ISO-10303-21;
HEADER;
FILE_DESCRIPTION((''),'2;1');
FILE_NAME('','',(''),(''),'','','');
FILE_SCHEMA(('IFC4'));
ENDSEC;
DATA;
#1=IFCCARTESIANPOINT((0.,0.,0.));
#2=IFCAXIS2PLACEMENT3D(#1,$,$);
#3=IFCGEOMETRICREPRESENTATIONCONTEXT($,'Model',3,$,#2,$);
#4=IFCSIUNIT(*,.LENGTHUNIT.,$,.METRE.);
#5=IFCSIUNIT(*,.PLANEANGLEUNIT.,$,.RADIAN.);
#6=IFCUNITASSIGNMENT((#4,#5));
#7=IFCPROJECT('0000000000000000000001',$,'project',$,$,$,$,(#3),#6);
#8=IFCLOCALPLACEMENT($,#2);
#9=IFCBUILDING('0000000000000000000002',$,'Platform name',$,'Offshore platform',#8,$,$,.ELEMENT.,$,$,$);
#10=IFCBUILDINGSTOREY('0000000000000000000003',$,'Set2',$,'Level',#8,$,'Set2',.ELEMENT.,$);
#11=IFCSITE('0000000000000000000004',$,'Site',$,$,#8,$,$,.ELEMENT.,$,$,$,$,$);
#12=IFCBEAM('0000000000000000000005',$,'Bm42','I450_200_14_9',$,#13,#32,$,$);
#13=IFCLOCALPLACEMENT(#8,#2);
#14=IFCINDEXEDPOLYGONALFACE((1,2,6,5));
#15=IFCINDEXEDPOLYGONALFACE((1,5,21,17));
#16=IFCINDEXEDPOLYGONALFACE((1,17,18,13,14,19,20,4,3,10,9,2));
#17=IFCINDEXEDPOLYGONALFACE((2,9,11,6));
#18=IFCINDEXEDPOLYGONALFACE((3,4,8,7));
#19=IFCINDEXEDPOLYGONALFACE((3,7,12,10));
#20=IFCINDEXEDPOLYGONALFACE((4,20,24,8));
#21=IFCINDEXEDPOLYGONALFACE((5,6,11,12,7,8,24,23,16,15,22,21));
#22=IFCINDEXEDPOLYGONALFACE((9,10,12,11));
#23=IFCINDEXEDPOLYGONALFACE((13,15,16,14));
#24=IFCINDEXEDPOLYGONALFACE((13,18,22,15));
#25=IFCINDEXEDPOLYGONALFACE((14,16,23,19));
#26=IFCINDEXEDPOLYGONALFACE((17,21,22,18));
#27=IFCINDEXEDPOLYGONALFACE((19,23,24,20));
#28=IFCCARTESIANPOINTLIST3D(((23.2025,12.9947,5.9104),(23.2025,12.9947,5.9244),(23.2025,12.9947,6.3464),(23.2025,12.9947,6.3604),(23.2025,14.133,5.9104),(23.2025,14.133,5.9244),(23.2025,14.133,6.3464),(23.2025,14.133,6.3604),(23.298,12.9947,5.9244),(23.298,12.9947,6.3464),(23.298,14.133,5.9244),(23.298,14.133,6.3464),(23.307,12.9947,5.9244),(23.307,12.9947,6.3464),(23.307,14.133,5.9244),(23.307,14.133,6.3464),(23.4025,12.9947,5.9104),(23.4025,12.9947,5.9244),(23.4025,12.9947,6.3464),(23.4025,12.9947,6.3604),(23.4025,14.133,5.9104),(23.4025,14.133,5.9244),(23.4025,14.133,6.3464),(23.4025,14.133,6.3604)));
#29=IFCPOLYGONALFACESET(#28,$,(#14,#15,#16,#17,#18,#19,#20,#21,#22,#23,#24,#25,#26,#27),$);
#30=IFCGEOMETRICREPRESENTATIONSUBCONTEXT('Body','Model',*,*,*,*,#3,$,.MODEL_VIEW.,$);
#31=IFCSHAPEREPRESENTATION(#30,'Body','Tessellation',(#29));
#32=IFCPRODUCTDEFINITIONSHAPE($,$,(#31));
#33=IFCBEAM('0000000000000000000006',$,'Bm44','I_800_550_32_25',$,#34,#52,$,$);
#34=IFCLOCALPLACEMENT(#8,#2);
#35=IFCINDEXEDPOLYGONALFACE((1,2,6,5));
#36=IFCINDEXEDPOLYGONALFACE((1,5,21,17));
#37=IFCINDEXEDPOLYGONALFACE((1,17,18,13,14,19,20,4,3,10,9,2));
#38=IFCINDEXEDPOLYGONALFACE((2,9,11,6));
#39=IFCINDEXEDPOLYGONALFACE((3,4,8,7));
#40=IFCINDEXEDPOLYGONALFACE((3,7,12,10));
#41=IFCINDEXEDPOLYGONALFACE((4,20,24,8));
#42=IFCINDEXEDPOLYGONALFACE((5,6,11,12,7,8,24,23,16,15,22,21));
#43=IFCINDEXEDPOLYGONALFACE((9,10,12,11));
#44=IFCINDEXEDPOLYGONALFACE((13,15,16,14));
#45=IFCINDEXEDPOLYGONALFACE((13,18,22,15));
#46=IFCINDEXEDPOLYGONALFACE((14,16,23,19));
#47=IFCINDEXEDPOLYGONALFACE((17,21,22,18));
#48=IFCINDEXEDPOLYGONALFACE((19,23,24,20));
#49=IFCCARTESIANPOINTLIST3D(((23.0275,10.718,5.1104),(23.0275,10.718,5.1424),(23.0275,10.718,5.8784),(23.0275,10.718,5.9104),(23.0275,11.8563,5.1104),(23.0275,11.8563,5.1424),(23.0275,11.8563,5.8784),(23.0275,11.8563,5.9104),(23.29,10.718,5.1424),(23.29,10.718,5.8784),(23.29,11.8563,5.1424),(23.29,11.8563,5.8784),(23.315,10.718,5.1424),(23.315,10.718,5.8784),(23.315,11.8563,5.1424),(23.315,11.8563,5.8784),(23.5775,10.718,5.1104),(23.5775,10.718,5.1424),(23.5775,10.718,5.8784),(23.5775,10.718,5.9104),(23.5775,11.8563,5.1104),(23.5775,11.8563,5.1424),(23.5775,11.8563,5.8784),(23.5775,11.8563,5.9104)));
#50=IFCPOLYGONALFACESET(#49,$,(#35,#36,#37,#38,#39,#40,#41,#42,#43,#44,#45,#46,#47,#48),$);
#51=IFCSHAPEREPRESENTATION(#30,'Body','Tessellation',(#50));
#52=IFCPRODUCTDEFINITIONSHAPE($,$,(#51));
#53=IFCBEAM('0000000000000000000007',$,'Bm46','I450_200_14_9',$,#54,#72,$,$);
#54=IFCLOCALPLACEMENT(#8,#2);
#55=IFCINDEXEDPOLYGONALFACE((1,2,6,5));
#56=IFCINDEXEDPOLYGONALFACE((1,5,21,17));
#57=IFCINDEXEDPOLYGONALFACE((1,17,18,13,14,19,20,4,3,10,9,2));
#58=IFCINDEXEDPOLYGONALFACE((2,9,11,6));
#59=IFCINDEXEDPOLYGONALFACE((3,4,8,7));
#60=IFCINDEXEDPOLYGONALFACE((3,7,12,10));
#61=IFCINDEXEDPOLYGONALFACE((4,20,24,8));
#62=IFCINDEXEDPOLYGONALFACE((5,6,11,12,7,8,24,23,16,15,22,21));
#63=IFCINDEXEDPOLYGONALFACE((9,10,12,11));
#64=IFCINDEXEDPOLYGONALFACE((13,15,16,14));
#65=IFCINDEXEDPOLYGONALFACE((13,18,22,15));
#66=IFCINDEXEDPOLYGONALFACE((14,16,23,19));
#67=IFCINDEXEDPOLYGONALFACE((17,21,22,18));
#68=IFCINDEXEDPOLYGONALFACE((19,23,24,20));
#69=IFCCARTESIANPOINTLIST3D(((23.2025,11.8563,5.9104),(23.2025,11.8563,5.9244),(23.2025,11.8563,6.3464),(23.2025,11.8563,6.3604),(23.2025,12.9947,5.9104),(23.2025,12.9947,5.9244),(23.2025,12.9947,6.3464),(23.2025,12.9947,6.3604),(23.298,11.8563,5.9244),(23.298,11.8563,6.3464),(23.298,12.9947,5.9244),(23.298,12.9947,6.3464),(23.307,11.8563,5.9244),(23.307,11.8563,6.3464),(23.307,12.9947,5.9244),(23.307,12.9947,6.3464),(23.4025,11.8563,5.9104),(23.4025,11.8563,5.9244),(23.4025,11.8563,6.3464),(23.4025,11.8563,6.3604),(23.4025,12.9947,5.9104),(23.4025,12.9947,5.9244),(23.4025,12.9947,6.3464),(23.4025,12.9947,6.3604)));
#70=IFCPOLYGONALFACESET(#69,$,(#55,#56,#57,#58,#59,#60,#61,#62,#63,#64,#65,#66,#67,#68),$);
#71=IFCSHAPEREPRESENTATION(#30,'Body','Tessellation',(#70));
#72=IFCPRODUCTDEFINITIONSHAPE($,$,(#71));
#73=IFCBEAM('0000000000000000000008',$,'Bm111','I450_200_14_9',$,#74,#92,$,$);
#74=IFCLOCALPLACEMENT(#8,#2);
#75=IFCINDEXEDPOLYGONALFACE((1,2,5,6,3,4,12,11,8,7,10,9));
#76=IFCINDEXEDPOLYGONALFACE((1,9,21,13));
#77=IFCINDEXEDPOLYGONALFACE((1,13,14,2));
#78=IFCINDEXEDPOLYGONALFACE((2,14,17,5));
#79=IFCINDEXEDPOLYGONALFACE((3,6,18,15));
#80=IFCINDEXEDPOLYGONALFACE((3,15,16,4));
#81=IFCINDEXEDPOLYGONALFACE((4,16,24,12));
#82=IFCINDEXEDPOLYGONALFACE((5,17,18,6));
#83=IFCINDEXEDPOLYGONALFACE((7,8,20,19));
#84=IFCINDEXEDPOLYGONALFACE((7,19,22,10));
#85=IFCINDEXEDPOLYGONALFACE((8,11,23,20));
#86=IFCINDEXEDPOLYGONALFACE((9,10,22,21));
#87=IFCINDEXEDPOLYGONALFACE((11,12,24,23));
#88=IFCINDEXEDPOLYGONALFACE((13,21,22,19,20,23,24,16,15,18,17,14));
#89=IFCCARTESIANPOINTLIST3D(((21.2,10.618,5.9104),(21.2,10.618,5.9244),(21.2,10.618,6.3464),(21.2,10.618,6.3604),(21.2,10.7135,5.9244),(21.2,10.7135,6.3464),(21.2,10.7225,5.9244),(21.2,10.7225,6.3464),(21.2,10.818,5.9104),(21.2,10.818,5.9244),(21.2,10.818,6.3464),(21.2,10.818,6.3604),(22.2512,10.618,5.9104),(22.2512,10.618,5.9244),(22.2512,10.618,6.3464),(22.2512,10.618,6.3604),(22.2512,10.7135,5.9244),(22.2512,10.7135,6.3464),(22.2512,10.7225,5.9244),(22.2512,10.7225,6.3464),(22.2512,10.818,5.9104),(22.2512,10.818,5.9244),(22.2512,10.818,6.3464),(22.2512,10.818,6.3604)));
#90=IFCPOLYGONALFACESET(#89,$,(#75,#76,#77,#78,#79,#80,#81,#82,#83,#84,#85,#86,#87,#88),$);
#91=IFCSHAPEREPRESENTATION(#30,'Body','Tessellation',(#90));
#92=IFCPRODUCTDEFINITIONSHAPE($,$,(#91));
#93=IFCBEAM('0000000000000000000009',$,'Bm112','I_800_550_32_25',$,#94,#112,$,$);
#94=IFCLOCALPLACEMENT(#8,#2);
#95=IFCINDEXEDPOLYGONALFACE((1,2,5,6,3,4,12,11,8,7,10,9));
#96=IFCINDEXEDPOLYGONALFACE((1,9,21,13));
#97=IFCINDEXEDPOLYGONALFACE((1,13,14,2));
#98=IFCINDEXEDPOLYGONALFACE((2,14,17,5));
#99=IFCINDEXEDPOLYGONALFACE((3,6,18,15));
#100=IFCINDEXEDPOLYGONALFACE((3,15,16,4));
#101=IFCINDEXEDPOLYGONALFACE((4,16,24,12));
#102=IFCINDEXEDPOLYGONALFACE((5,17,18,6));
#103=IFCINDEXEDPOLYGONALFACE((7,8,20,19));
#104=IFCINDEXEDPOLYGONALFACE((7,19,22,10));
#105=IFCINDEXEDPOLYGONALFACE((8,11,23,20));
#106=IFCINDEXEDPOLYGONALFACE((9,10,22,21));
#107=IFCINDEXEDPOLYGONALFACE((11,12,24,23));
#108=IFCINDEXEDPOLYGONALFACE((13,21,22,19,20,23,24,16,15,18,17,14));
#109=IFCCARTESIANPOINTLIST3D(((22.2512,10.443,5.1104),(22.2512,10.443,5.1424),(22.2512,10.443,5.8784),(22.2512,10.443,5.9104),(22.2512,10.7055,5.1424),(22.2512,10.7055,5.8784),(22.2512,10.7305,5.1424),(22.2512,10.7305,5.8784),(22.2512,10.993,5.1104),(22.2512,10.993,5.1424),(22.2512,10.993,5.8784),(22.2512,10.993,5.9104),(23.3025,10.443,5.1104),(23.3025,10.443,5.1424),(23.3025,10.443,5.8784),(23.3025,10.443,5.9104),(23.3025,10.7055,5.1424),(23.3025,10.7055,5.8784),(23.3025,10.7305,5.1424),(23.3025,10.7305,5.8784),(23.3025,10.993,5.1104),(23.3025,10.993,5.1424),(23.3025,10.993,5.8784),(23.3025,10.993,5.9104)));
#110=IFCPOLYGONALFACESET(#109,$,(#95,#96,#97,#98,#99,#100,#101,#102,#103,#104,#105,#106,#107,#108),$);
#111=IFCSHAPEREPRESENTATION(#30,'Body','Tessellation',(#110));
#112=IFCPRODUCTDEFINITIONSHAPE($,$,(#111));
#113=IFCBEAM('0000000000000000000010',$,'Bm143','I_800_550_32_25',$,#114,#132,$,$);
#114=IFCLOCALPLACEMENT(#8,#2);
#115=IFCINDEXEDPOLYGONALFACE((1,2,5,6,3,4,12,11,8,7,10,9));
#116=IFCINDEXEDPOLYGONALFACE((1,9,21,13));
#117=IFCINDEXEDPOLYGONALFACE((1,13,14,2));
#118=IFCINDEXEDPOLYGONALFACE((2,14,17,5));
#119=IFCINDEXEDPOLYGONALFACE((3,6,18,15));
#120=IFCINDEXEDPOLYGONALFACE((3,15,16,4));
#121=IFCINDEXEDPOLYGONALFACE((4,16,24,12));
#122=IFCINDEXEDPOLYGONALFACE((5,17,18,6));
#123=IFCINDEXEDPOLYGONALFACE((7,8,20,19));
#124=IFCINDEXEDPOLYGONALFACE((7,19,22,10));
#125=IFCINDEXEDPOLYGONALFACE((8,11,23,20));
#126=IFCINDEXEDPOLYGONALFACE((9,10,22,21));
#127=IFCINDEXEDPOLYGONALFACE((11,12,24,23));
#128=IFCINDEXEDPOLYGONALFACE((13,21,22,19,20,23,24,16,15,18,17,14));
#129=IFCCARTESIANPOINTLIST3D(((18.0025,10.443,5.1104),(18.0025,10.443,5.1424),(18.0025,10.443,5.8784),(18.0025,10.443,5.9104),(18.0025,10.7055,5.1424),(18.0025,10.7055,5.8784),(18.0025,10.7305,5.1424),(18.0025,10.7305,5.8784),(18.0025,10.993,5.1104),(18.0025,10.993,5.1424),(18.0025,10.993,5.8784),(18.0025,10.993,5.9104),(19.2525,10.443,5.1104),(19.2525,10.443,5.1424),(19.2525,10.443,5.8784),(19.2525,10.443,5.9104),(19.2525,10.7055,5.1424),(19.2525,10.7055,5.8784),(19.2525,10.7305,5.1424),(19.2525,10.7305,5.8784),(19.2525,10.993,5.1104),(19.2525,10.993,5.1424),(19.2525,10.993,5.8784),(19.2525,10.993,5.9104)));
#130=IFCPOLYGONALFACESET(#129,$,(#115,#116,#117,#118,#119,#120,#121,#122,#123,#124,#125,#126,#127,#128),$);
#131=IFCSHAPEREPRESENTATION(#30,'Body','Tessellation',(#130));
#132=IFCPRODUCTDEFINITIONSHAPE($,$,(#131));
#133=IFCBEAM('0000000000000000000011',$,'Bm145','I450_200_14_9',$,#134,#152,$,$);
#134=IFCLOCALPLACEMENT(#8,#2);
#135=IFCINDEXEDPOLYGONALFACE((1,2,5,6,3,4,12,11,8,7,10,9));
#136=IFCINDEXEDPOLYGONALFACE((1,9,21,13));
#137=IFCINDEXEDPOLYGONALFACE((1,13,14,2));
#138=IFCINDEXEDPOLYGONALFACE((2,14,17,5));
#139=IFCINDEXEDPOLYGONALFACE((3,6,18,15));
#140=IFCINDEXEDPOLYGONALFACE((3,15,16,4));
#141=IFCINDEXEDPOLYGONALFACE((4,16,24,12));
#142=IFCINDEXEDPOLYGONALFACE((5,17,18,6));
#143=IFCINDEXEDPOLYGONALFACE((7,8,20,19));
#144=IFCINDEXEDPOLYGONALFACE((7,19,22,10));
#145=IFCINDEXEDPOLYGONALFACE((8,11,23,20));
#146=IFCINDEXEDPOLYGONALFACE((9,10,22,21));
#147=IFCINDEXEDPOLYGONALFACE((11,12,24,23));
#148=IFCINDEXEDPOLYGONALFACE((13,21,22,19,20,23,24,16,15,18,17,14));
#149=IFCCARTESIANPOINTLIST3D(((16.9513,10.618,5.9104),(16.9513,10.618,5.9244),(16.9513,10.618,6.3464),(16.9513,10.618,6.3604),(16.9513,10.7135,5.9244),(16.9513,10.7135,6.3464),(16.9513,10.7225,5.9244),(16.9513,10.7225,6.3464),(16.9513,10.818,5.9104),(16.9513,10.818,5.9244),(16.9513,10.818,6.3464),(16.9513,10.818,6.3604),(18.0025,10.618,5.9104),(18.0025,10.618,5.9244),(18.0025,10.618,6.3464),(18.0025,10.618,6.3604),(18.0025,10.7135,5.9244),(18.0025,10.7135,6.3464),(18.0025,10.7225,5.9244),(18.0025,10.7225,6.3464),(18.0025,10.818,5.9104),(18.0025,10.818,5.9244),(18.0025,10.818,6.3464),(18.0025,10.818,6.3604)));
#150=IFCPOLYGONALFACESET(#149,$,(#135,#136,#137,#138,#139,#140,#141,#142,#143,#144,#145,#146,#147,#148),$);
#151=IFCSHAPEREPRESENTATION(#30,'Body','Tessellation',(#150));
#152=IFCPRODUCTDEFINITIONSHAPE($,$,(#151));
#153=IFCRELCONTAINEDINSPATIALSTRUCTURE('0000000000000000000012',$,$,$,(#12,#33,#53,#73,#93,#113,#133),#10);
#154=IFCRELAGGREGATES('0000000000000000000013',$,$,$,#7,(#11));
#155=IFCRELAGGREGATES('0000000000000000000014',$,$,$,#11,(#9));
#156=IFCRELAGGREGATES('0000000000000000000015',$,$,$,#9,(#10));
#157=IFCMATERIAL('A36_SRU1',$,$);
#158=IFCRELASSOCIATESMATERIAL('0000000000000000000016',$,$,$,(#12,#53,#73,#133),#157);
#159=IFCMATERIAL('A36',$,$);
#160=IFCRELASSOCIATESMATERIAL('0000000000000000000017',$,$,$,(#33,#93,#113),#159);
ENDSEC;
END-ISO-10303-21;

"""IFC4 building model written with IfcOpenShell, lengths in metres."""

from ifc_helpers import new_model, si_unit, frame, origin, origin_2d, place, context, subcontext, project, spatial, i_section, extrude, source, transform, mapped, material, element, save


model = new_model("IFC4")

# Units and contexts
model_context = context("Model", 3, world=origin())
body_context = subcontext(model_context, "Body", "Model", "MODEL_VIEW")
ifc_project = project(units=[si_unit("LENGTHUNIT", "METRE"), si_unit("PLANEANGLEUNIT", "RADIAN")], contexts=[model_context])

# Site, building, storey
placement_1 = place(None, origin())
site = spatial("IfcSite", under=ifc_project, at=placement_1, Name="Site", CompositionType="ELEMENT")
building = spatial("IfcBuilding", under=site, at=placement_1, Name="Platform name", ObjectType="Offshore platform", CompositionType="ELEMENT")
storey = spatial("IfcBuildingStorey", under=building, at=placement_1, Name="Set2", ObjectType="Level", LongName="Set2", CompositionType="ELEMENT")

# Beams
ifc_material_1 = material(Name="A36_SRU1")
ifc_material_2 = material(Name="A36")
shared_shape_1 = source(origin(), body_context, "Body", "SweptSolid", [
    extrude(i_section(OverallWidth=0.2, OverallDepth=0.45, WebThickness=0.009, FlangeThickness=0.014, FilletRadius=0.0, at=origin_2d()), frame((0.0, 0.0, 0.0), z_axis=(0.0, 1.0, 0.0), x_axis=(-1.0, 0.0, 0.0)), (0.0, 0.0, 1.0), 1.1383),
])
placement_2 = place(None, origin())
placement_3 = place(placement_2, origin())
placement_4 = place(placement_3, origin())
beam_1_placement = place(placement_4, frame((23.3025, 12.9947, 6.1354)))
element("IfcBeam", 1, at=beam_1_placement, inside=storey, material=ifc_material_1, Name="Bm42", Description="I450_200_14_9", context=body_context, shape_type="MappedRepresentation", body=[
    mapped(shared_shape_1, transform((0.0, 0.0, 0.0), scale=1.0)),
])
shared_shape_2 = source(origin(), body_context, "Body", "SweptSolid", [
    extrude(i_section(OverallWidth=0.55, OverallDepth=0.8, WebThickness=0.025, FlangeThickness=0.032, FilletRadius=0.0, at=origin_2d()), frame((0.0, 0.0, 0.0), z_axis=(0.0, -1.0, 0.0), x_axis=(1.0, 0.0, 0.0)), (0.0, 0.0, 1.0), 1.1383),
])
placement_5 = place(None, origin())
placement_6 = place(placement_5, origin())
placement_7 = place(placement_6, origin())
beam_2_placement = place(placement_7, frame((23.3025, 11.8563, 5.5104)))
element("IfcBeam", 2, at=beam_2_placement, inside=storey, material=ifc_material_2, Name="Bm44", Description="I_800_550_32_25", context=body_context, shape_type="MappedRepresentation", body=[
    mapped(shared_shape_2, transform((0.0, 0.0, 0.0), scale=1.0)),
])
shared_shape_3 = source(origin(), body_context, "Body", "SweptSolid", [
    extrude(i_section(OverallWidth=0.2, OverallDepth=0.45, WebThickness=0.009, FlangeThickness=0.014, FilletRadius=0.0, at=origin_2d()), frame((0.0, 0.0, 0.0), z_axis=(0.0, 1.0, 0.0), x_axis=(-1.0, 0.0, 0.0)), (0.0, 0.0, 1.0), 1.1383),
])
placement_8 = place(None, origin())
placement_9 = place(placement_8, origin())
placement_10 = place(placement_9, origin())
beam_3_placement = place(placement_10, frame((23.3025, 11.8563, 6.1354)))
element("IfcBeam", 3, at=beam_3_placement, inside=storey, material=ifc_material_1, Name="Bm46", Description="I450_200_14_9", context=body_context, shape_type="MappedRepresentation", body=[
    mapped(shared_shape_3, transform((0.0, 0.0, 0.0), scale=1.0)),
])
shared_shape_4 = source(origin(), body_context, "Body", "SweptSolid", [
    extrude(i_section(OverallWidth=0.2, OverallDepth=0.45, WebThickness=0.009, FlangeThickness=0.014, FilletRadius=0.0, at=origin_2d()), frame((0.0, 0.0, 0.0), z_axis=(-1.0, 0.0, 0.0), x_axis=(0.0, -1.0, 0.0)), (0.0, 0.0, 1.0), 1.0513),
])
placement_11 = place(None, origin())
placement_12 = place(placement_11, origin())
placement_13 = place(placement_12, origin())
beam_4_placement = place(placement_13, frame((22.2512, 10.718, 6.1354)))
element("IfcBeam", 4, at=beam_4_placement, inside=storey, material=ifc_material_1, Name="Bm111", Description="I450_200_14_9", context=body_context, shape_type="MappedRepresentation", body=[
    mapped(shared_shape_4, transform((0.0, 0.0, 0.0), scale=1.0)),
])
shared_shape_5 = source(origin(), body_context, "Body", "SweptSolid", [
    extrude(i_section(OverallWidth=0.55, OverallDepth=0.8, WebThickness=0.025, FlangeThickness=0.032, FilletRadius=0.0, at=origin_2d()), frame((0.0, 0.0, 0.0), z_axis=(1.0, 0.0, 0.0), x_axis=(0.0, 1.0, 0.0)), (0.0, 0.0, 1.0), 1.0513),
])
placement_14 = place(None, origin())
placement_15 = place(placement_14, origin())
placement_16 = place(placement_15, origin())
beam_5_placement = place(placement_16, frame((22.2512, 10.718, 5.5104)))
element("IfcBeam", 5, at=beam_5_placement, inside=storey, material=ifc_material_2, Name="Bm112", Description="I_800_550_32_25", context=body_context, shape_type="MappedRepresentation", body=[
    mapped(shared_shape_5, transform((0.0, 0.0, 0.0), scale=1.0)),
])
shared_shape_6 = source(origin(), body_context, "Body", "SweptSolid", [
    extrude(i_section(OverallWidth=0.55, OverallDepth=0.8, WebThickness=0.025, FlangeThickness=0.032, FilletRadius=0.0, at=origin_2d()), frame((0.0, 0.0, 0.0), z_axis=(1.0, 0.0, 0.0), x_axis=(0.0, 1.0, 0.0)), (0.0, 0.0, 1.0), 1.25),
])
placement_17 = place(None, origin())
placement_18 = place(placement_17, origin())
placement_19 = place(placement_18, origin())
beam_6_placement = place(placement_19, frame((18.0025, 10.718, 5.5104)))
element("IfcBeam", 6, at=beam_6_placement, inside=storey, material=ifc_material_2, Name="Bm143", Description="I_800_550_32_25", context=body_context, shape_type="MappedRepresentation", body=[
    mapped(shared_shape_6, transform((0.0, 0.0, 0.0), scale=1.0)),
])
shared_shape_7 = source(origin(), body_context, "Body", "SweptSolid", [
    extrude(i_section(OverallWidth=0.2, OverallDepth=0.45, WebThickness=0.009, FlangeThickness=0.014, FilletRadius=0.0, at=origin_2d()), frame((0.0, 0.0, 0.0), z_axis=(-1.0, 0.0, 0.0), x_axis=(0.0, -1.0, 0.0)), (0.0, 0.0, 1.0), 1.0513),
])
placement_20 = place(None, origin())
placement_21 = place(placement_20, origin())
placement_22 = place(placement_21, origin())
beam_7_placement = place(placement_22, frame((18.0025, 10.718, 6.1354)))
element("IfcBeam", 7, at=beam_7_placement, inside=storey, material=ifc_material_1, Name="Bm145", Description="I450_200_14_9", context=body_context, shape_type="MappedRepresentation", body=[
    mapped(shared_shape_7, transform((0.0, 0.0, 0.0), scale=1.0)),
])

save(model, "model.ifc")
